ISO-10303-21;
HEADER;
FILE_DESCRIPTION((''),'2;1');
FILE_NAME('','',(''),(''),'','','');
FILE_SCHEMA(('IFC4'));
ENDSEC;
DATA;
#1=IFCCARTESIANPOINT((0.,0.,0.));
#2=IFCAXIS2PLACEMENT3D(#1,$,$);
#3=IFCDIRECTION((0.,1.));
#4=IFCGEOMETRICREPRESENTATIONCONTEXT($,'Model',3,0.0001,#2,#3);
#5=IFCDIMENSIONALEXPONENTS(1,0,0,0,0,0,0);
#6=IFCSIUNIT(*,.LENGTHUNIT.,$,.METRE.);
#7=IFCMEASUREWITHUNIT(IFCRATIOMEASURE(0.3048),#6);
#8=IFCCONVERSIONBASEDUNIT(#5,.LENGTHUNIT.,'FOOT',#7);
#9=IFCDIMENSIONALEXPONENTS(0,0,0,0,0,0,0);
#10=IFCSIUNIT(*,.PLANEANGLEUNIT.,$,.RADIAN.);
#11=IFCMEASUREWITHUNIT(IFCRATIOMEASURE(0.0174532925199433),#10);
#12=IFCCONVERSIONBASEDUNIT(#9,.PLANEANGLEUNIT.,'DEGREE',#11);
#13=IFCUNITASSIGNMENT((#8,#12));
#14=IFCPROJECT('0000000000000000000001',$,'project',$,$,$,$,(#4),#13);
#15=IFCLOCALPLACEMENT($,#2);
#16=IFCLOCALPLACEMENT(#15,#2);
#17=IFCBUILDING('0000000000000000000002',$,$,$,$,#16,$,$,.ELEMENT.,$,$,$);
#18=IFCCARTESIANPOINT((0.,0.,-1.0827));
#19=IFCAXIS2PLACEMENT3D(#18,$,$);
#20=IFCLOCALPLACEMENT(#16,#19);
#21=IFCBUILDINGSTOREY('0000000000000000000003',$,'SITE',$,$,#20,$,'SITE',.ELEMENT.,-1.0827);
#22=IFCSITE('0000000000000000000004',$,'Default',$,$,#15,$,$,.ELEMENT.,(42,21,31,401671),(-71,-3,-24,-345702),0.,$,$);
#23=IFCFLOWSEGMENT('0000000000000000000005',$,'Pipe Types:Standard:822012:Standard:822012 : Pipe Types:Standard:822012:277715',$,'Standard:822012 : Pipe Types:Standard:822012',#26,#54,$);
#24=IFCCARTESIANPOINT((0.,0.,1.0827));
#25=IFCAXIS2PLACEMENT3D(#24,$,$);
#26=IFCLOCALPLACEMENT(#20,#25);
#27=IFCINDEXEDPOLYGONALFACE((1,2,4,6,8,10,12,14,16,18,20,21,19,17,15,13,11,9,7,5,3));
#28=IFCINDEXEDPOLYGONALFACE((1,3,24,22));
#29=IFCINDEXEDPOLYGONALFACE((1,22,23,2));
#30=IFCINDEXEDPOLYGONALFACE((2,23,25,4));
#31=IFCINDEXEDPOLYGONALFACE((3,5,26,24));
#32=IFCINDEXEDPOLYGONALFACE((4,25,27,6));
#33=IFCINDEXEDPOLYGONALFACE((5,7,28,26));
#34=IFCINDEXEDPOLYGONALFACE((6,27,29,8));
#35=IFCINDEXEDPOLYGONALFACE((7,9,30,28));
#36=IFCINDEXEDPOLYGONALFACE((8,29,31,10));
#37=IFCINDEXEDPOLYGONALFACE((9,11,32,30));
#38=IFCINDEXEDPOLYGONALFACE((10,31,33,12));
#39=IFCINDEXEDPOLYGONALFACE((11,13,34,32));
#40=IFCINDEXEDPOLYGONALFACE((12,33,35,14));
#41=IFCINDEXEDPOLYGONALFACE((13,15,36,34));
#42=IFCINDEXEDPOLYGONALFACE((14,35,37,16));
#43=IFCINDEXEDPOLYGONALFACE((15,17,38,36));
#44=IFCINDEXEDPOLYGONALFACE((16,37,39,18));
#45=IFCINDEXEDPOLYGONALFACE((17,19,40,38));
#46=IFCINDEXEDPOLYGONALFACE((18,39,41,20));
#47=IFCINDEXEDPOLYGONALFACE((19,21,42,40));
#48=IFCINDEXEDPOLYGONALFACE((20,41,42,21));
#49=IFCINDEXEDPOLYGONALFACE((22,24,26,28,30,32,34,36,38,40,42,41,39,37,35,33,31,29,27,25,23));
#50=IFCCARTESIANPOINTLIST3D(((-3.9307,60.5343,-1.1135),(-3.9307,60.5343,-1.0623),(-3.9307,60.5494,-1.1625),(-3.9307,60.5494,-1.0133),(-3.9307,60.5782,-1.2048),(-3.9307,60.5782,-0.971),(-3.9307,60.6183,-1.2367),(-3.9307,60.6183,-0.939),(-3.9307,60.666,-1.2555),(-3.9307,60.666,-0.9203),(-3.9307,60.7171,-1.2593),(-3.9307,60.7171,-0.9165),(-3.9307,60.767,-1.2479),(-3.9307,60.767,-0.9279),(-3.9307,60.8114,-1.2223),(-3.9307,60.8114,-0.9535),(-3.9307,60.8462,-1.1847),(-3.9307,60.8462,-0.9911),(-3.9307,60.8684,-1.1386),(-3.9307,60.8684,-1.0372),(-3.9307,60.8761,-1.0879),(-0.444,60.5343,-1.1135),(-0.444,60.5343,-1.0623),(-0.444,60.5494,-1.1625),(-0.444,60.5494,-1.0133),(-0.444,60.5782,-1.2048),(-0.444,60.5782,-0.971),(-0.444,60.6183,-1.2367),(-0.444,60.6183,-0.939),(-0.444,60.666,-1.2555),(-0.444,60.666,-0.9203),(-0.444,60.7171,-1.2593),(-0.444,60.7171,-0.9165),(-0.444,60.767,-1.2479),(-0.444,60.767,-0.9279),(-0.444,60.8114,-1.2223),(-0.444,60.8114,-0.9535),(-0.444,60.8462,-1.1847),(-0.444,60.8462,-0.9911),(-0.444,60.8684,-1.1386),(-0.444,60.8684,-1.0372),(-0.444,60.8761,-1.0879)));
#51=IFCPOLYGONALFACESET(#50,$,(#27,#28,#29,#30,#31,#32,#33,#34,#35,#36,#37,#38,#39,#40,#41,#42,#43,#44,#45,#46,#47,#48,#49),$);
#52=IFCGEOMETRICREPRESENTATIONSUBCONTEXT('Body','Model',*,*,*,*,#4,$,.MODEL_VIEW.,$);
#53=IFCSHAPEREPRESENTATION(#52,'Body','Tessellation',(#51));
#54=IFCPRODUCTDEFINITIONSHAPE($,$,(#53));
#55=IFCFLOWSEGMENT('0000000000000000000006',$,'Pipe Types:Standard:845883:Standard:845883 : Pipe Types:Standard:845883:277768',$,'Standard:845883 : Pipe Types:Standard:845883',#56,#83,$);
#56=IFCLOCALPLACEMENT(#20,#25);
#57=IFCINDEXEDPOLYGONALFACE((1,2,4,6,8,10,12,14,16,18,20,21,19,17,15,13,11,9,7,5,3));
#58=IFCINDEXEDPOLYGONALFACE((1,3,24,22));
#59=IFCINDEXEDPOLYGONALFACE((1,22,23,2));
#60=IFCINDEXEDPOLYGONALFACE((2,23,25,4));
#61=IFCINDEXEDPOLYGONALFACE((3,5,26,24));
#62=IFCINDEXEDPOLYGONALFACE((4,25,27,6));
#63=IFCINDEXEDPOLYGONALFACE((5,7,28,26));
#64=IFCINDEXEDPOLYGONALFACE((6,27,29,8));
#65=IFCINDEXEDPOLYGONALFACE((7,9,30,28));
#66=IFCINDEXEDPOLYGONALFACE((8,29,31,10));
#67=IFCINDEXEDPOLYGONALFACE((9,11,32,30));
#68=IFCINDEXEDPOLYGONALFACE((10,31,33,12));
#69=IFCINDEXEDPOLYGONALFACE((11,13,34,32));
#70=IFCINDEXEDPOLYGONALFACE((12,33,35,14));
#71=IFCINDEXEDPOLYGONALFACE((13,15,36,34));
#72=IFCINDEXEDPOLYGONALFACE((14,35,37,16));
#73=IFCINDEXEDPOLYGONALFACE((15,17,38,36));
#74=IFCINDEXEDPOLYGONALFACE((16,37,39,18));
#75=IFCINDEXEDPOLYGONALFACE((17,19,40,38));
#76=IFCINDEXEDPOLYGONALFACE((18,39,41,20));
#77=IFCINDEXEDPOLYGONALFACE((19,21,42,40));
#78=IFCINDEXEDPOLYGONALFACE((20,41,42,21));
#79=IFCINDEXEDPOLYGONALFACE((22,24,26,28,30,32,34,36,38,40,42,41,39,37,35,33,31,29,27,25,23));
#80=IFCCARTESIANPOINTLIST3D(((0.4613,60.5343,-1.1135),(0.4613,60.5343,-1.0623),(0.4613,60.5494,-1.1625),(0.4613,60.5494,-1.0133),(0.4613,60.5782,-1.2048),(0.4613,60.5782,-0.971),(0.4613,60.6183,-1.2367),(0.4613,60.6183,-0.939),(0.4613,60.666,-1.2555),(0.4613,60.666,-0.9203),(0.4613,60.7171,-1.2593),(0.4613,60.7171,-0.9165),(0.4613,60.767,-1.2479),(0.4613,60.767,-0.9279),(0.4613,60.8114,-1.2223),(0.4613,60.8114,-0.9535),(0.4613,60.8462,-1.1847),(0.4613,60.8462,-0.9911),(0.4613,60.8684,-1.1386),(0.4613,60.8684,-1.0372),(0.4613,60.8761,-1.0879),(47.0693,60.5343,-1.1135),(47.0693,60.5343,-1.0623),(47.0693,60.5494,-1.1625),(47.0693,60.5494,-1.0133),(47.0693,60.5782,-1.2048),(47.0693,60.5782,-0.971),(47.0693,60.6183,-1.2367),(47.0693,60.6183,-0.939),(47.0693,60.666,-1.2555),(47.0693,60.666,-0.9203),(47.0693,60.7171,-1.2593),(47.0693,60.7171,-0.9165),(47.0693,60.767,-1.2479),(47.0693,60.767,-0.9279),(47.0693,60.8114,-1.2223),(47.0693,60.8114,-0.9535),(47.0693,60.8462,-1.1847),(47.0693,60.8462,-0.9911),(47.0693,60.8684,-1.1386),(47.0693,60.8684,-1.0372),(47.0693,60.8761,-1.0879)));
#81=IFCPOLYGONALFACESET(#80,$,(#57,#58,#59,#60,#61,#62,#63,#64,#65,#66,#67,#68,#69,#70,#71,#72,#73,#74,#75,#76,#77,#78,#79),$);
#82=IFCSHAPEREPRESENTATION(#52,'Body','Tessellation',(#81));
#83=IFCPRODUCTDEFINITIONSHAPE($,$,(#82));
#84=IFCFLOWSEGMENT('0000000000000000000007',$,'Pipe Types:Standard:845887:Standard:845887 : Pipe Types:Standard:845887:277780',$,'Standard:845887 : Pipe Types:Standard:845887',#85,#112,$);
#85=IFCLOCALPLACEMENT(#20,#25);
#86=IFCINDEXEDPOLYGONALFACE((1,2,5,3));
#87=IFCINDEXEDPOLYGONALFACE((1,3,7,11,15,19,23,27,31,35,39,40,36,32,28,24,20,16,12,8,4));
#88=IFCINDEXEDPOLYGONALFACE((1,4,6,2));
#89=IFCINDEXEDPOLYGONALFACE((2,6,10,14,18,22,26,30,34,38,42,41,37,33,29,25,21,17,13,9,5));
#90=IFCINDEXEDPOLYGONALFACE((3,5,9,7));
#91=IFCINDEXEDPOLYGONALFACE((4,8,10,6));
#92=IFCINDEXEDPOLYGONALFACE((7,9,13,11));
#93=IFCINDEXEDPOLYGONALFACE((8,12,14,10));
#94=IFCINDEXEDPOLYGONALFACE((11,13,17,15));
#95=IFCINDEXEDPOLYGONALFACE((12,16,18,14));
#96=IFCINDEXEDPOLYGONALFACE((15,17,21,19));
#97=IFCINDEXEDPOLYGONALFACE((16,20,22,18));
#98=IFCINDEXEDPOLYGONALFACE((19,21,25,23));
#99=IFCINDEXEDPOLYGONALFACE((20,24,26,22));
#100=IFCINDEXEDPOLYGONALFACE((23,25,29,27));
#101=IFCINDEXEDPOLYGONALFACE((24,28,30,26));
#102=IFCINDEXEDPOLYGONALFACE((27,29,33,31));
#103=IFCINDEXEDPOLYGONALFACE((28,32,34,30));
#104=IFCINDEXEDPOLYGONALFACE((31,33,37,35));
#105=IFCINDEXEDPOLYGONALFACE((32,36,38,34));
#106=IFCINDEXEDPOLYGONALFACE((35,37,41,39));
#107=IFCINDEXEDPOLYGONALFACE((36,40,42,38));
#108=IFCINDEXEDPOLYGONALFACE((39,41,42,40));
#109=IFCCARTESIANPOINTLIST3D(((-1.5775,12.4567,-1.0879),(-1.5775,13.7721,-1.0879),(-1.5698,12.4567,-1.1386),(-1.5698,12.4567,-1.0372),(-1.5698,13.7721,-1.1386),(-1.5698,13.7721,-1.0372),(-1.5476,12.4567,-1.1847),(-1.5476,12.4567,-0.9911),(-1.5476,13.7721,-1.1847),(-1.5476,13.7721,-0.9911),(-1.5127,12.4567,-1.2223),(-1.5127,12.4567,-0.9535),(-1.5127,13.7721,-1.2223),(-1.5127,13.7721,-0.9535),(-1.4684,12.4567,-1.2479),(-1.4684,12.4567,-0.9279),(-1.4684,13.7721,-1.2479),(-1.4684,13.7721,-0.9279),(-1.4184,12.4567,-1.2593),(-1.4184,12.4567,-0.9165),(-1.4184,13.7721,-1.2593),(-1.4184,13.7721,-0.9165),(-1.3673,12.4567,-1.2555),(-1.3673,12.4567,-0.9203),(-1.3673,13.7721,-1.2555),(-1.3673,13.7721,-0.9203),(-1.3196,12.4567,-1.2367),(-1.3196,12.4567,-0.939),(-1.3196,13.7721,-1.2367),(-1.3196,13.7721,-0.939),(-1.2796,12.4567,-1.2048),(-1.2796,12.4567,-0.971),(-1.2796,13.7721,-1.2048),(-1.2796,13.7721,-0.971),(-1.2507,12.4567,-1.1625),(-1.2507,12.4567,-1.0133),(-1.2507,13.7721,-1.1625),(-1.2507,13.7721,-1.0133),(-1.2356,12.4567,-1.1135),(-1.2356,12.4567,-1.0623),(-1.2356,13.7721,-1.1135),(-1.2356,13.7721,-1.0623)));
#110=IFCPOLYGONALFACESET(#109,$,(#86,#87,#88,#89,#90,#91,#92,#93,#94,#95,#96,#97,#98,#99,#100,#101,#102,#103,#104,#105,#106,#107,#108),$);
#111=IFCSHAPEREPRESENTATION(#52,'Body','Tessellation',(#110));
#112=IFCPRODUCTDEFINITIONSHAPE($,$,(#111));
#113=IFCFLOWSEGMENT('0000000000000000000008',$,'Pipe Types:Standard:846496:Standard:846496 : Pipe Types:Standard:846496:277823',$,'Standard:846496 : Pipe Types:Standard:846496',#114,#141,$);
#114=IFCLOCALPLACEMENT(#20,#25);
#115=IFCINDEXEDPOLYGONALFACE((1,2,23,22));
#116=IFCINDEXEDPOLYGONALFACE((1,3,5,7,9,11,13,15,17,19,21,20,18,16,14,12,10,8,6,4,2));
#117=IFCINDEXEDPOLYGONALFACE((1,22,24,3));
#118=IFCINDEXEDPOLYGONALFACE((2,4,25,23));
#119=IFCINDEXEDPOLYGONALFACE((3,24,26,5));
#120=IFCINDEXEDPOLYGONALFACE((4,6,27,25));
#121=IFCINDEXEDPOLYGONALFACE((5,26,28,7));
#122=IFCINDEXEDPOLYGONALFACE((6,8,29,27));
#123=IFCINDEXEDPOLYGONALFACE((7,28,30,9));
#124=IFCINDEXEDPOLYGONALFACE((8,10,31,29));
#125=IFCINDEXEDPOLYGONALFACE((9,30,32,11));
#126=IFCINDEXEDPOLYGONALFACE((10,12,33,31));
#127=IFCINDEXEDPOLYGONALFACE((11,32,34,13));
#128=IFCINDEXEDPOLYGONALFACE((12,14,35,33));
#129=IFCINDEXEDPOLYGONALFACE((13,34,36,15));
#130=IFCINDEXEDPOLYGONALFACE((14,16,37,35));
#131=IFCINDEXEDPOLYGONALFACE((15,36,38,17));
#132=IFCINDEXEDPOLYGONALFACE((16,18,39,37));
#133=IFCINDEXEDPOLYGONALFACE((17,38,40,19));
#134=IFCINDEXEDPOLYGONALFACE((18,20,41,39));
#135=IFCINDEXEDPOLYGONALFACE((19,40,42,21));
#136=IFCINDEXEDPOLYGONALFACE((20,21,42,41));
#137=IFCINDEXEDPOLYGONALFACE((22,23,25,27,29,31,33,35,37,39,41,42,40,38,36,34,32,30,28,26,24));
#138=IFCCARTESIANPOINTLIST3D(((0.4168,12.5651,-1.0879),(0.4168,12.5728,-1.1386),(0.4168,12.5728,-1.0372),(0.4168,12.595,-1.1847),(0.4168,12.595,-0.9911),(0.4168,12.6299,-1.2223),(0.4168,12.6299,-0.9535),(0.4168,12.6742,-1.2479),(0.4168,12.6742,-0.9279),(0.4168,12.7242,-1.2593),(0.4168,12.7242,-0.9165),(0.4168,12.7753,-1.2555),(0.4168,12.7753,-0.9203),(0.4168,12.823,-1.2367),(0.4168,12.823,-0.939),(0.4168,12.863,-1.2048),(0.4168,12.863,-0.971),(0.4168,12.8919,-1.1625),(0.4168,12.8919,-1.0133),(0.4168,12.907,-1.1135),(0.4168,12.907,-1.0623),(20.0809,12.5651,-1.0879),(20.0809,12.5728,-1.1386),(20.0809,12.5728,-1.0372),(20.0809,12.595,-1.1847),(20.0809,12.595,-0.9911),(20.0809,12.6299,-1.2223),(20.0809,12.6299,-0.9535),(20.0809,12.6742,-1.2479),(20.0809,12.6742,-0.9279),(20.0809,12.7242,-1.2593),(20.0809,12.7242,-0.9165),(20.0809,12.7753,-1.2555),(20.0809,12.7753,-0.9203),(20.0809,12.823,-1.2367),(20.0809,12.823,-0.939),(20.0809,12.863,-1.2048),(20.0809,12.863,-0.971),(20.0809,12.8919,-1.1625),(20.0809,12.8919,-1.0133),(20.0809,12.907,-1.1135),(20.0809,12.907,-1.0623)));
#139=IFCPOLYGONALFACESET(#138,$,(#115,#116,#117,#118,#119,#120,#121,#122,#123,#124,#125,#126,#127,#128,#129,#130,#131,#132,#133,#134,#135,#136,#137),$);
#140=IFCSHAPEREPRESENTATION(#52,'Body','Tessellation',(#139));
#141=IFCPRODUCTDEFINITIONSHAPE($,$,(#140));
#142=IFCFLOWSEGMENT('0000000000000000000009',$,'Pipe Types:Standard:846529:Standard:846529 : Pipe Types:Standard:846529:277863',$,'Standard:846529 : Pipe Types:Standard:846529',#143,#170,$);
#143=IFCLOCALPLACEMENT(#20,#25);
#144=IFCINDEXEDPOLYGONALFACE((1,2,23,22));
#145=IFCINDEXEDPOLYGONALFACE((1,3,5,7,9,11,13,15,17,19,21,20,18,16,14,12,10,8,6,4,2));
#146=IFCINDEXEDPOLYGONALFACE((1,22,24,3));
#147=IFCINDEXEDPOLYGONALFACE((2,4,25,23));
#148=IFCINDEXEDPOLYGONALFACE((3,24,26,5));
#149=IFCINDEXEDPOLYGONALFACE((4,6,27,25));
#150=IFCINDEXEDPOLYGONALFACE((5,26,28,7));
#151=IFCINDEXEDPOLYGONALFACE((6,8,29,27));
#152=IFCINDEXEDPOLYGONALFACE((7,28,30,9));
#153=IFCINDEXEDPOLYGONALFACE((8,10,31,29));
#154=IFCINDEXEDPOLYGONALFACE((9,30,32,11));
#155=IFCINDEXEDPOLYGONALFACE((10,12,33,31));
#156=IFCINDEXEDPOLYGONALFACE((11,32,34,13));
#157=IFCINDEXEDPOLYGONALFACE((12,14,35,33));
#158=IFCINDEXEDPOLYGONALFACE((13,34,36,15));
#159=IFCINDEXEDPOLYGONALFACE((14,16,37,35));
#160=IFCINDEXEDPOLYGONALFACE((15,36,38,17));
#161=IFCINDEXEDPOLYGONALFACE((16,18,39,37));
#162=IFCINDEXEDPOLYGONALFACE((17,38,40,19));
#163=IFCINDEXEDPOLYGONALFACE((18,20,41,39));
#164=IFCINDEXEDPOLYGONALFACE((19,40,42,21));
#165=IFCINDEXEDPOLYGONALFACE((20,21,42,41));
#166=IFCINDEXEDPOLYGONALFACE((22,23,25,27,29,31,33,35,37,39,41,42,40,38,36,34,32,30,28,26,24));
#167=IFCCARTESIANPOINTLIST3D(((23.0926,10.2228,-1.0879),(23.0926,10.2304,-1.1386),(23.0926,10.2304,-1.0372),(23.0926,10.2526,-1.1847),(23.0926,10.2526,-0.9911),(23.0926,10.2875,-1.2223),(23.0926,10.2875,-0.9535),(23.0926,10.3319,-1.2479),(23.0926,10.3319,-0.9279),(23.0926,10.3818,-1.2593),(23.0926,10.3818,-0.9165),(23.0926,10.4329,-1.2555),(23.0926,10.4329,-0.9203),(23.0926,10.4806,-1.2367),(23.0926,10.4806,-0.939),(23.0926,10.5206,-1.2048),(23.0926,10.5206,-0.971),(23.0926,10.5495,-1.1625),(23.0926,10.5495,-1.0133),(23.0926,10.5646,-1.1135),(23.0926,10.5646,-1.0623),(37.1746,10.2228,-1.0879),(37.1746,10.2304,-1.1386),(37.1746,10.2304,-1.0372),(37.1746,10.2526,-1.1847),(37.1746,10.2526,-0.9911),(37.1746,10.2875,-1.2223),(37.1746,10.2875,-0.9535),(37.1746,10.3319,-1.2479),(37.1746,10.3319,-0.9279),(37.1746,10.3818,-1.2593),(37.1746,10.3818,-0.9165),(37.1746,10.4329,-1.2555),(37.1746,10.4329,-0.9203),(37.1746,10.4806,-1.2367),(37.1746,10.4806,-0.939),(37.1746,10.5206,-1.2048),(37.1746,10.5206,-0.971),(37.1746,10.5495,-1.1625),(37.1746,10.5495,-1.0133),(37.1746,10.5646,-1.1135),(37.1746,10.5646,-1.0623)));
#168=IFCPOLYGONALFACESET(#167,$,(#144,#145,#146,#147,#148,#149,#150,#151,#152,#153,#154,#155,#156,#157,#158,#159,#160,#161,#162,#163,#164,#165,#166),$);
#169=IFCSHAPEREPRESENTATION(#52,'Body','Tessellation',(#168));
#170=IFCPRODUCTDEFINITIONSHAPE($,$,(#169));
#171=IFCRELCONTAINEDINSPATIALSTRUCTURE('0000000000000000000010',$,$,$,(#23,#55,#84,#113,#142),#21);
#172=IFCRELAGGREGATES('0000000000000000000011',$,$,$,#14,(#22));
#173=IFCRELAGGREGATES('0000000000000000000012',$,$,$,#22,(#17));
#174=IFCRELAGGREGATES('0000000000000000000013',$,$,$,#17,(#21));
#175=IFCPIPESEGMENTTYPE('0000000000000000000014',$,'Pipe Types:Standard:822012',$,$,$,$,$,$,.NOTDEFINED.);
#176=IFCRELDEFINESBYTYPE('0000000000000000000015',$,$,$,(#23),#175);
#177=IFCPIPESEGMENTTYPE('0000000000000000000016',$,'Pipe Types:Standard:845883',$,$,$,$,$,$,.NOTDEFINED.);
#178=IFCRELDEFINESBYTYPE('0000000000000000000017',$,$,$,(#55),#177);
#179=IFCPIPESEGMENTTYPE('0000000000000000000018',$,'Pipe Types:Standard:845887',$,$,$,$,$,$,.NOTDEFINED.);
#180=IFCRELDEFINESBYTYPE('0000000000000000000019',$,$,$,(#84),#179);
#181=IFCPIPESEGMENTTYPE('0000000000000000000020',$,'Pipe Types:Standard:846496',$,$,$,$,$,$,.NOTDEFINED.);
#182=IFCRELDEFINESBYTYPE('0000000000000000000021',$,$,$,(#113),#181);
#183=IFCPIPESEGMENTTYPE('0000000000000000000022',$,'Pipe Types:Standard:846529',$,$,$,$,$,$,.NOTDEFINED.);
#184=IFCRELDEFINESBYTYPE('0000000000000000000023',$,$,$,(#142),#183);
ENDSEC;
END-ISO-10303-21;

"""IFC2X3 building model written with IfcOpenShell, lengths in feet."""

from ifc_helpers import new_model, entity, si_unit, converted_unit, direction, frame, frame_2d, origin, place, context, subcontext, project, spatial, circle, extrude, source, transform, mapped, type_object, type_shapes, element, save


model = new_model("IFC2X3")

# Units and contexts
model_context = context("Model", 3, precision=0.0001, world=origin(), true_north=direction((0.0, 1.0)))
body_context = subcontext(model_context, "Body", "Model", "MODEL_VIEW")
ifc_project = project(units=[converted_unit("LENGTHUNIT", "FOOT", entity("IfcRatioMeasure", 0.3048), si_unit("LENGTHUNIT", "METRE"), dimensions=[1, 0, 0, 0, 0, 0, 0]), converted_unit("PLANEANGLEUNIT", "DEGREE", entity("IfcRatioMeasure", 0.0174532925199433), si_unit("PLANEANGLEUNIT", "RADIAN"), dimensions=[0, 0, 0, 0, 0, 0, 0])], contexts=[model_context])

# Site, building, storey
site_placement = place(None, origin())
site = spatial("IfcSite", under=ifc_project, at=site_placement, Name="Default", CompositionType="ELEMENT", RefLatitude=(42, 21, 31, 401671), RefLongitude=(-71, -3, -24, -345702), RefElevation=0.0)
building_placement = place(site_placement, origin())
building = spatial("IfcBuilding", under=site, at=building_placement, CompositionType="ELEMENT")
storey_placement = place(building_placement, frame((0.0, 0.0, -1.0827)))
storey = spatial("IfcBuildingStorey", under=building, at=storey_placement, Name="SITE", LongName="SITE", CompositionType="ELEMENT", Elevation=-1.0827)

# Flow segments
pipe_segment_type_1 = type_object("IfcPipeSegmentType", Name="Pipe Types:Standard:822012", PredefinedType="NOTDEFINED")
shared_shape_1 = source(origin(), body_context, "Body", "SweptSolid", [
    extrude(circle(Radius=0.1719, at=frame_2d((0.0, 0.0), x_axis=(1.0, 0.0))), frame((-3.9307, 60.7042, -1.0879), z_axis=(1.0, 0.0, 0.0), x_axis=(0.0, 1.0, 0.0)), (0.0, 0.0, 1.0), 3.4867),
])
type_shapes(pipe_segment_type_1, [shared_shape_1])
flow_segment_1_placement = place(storey_placement, frame((0.0, 0.0, 1.0827)))
element("IfcFlowSegment", 1, at=flow_segment_1_placement, inside=storey, type_object=pipe_segment_type_1, Name="Pipe Types:Standard:822012:Standard:822012 : Pipe Types:Standard:822012:277715", ObjectType="Standard:822012 : Pipe Types:Standard:822012", context=body_context, shape_type="MappedRepresentation", body=[
    mapped(shared_shape_1, transform((0.0, 0.0, 0.0), scale=1.0)),
])
pipe_segment_type_2 = type_object("IfcPipeSegmentType", Name="Pipe Types:Standard:845883", PredefinedType="NOTDEFINED")
shared_shape_2 = source(origin(), body_context, "Body", "SweptSolid", [
    extrude(circle(Radius=0.1719, at=frame_2d((0.0, 0.0), x_axis=(1.0, 0.0))), frame((0.4613, 60.7042, -1.0879), z_axis=(1.0, 0.0, 0.0), x_axis=(0.0, 1.0, 0.0)), (0.0, 0.0, 1.0), 46.608),
])
type_shapes(pipe_segment_type_2, [shared_shape_2])
flow_segment_2_placement = place(storey_placement, frame((0.0, 0.0, 1.0827)))
element("IfcFlowSegment", 2, at=flow_segment_2_placement, inside=storey, type_object=pipe_segment_type_2, Name="Pipe Types:Standard:845883:Standard:845883 : Pipe Types:Standard:845883:277768", ObjectType="Standard:845883 : Pipe Types:Standard:845883", context=body_context, shape_type="MappedRepresentation", body=[
    mapped(shared_shape_2, transform((0.0, 0.0, 0.0), scale=1.0)),
])
pipe_segment_type_3 = type_object("IfcPipeSegmentType", Name="Pipe Types:Standard:845887", PredefinedType="NOTDEFINED")
shared_shape_3 = source(origin(), body_context, "Body", "SweptSolid", [
    extrude(circle(Radius=0.1719, at=frame_2d((0.0, 0.0), x_axis=(1.0, 0.0))), frame((-1.4056, 12.4567, -1.0879), z_axis=(0.0, 1.0, 0.0), x_axis=(-1.0, 0.0, 0.0)), (0.0, 0.0, 1.0), 1.3155),
])
type_shapes(pipe_segment_type_3, [shared_shape_3])
flow_segment_3_placement = place(storey_placement, frame((0.0, 0.0, 1.0827)))
element("IfcFlowSegment", 3, at=flow_segment_3_placement, inside=storey, type_object=pipe_segment_type_3, Name="Pipe Types:Standard:845887:Standard:845887 : Pipe Types:Standard:845887:277780", ObjectType="Standard:845887 : Pipe Types:Standard:845887", context=body_context, shape_type="MappedRepresentation", body=[
    mapped(shared_shape_3, transform((0.0, 0.0, 0.0), scale=1.0)),
])
pipe_segment_type_4 = type_object("IfcPipeSegmentType", Name="Pipe Types:Standard:846496", PredefinedType="NOTDEFINED")
shared_shape_4 = source(origin(), body_context, "Body", "SweptSolid", [
    extrude(circle(Radius=0.1719, at=frame_2d((0.0, 0.0), x_axis=(1.0, 0.0))), frame((0.4168, 12.737, -1.0879), z_axis=(1.0, 0.0, 0.0), x_axis=(0.0, -1.0, 0.0)), (0.0, 0.0, 1.0), 19.664),
])
type_shapes(pipe_segment_type_4, [shared_shape_4])
flow_segment_4_placement = place(storey_placement, frame((0.0, 0.0, 1.0827)))
element("IfcFlowSegment", 4, at=flow_segment_4_placement, inside=storey, type_object=pipe_segment_type_4, Name="Pipe Types:Standard:846496:Standard:846496 : Pipe Types:Standard:846496:277823", ObjectType="Standard:846496 : Pipe Types:Standard:846496", context=body_context, shape_type="MappedRepresentation", body=[
    mapped(shared_shape_4, transform((0.0, 0.0, 0.0), scale=1.0)),
])
pipe_segment_type_5 = type_object("IfcPipeSegmentType", Name="Pipe Types:Standard:846529", PredefinedType="NOTDEFINED")
shared_shape_5 = source(origin(), body_context, "Body", "SweptSolid", [
    extrude(circle(Radius=0.1719, at=frame_2d((0.0, 0.0), x_axis=(1.0, 0.0))), frame((23.0926, 10.3946, -1.0879), z_axis=(1.0, 0.0, 0.0), x_axis=(0.0, -1.0, 0.0)), (0.0, 0.0, 1.0), 14.082),
])
type_shapes(pipe_segment_type_5, [shared_shape_5])
flow_segment_5_placement = place(storey_placement, frame((0.0, 0.0, 1.0827)))
element("IfcFlowSegment", 5, at=flow_segment_5_placement, inside=storey, type_object=pipe_segment_type_5, Name="Pipe Types:Standard:846529:Standard:846529 : Pipe Types:Standard:846529:277863", ObjectType="Standard:846529 : Pipe Types:Standard:846529", context=body_context, shape_type="MappedRepresentation", body=[
    mapped(shared_shape_5, transform((0.0, 0.0, 0.0), scale=1.0)),
])

save(model, "model.ifc")
